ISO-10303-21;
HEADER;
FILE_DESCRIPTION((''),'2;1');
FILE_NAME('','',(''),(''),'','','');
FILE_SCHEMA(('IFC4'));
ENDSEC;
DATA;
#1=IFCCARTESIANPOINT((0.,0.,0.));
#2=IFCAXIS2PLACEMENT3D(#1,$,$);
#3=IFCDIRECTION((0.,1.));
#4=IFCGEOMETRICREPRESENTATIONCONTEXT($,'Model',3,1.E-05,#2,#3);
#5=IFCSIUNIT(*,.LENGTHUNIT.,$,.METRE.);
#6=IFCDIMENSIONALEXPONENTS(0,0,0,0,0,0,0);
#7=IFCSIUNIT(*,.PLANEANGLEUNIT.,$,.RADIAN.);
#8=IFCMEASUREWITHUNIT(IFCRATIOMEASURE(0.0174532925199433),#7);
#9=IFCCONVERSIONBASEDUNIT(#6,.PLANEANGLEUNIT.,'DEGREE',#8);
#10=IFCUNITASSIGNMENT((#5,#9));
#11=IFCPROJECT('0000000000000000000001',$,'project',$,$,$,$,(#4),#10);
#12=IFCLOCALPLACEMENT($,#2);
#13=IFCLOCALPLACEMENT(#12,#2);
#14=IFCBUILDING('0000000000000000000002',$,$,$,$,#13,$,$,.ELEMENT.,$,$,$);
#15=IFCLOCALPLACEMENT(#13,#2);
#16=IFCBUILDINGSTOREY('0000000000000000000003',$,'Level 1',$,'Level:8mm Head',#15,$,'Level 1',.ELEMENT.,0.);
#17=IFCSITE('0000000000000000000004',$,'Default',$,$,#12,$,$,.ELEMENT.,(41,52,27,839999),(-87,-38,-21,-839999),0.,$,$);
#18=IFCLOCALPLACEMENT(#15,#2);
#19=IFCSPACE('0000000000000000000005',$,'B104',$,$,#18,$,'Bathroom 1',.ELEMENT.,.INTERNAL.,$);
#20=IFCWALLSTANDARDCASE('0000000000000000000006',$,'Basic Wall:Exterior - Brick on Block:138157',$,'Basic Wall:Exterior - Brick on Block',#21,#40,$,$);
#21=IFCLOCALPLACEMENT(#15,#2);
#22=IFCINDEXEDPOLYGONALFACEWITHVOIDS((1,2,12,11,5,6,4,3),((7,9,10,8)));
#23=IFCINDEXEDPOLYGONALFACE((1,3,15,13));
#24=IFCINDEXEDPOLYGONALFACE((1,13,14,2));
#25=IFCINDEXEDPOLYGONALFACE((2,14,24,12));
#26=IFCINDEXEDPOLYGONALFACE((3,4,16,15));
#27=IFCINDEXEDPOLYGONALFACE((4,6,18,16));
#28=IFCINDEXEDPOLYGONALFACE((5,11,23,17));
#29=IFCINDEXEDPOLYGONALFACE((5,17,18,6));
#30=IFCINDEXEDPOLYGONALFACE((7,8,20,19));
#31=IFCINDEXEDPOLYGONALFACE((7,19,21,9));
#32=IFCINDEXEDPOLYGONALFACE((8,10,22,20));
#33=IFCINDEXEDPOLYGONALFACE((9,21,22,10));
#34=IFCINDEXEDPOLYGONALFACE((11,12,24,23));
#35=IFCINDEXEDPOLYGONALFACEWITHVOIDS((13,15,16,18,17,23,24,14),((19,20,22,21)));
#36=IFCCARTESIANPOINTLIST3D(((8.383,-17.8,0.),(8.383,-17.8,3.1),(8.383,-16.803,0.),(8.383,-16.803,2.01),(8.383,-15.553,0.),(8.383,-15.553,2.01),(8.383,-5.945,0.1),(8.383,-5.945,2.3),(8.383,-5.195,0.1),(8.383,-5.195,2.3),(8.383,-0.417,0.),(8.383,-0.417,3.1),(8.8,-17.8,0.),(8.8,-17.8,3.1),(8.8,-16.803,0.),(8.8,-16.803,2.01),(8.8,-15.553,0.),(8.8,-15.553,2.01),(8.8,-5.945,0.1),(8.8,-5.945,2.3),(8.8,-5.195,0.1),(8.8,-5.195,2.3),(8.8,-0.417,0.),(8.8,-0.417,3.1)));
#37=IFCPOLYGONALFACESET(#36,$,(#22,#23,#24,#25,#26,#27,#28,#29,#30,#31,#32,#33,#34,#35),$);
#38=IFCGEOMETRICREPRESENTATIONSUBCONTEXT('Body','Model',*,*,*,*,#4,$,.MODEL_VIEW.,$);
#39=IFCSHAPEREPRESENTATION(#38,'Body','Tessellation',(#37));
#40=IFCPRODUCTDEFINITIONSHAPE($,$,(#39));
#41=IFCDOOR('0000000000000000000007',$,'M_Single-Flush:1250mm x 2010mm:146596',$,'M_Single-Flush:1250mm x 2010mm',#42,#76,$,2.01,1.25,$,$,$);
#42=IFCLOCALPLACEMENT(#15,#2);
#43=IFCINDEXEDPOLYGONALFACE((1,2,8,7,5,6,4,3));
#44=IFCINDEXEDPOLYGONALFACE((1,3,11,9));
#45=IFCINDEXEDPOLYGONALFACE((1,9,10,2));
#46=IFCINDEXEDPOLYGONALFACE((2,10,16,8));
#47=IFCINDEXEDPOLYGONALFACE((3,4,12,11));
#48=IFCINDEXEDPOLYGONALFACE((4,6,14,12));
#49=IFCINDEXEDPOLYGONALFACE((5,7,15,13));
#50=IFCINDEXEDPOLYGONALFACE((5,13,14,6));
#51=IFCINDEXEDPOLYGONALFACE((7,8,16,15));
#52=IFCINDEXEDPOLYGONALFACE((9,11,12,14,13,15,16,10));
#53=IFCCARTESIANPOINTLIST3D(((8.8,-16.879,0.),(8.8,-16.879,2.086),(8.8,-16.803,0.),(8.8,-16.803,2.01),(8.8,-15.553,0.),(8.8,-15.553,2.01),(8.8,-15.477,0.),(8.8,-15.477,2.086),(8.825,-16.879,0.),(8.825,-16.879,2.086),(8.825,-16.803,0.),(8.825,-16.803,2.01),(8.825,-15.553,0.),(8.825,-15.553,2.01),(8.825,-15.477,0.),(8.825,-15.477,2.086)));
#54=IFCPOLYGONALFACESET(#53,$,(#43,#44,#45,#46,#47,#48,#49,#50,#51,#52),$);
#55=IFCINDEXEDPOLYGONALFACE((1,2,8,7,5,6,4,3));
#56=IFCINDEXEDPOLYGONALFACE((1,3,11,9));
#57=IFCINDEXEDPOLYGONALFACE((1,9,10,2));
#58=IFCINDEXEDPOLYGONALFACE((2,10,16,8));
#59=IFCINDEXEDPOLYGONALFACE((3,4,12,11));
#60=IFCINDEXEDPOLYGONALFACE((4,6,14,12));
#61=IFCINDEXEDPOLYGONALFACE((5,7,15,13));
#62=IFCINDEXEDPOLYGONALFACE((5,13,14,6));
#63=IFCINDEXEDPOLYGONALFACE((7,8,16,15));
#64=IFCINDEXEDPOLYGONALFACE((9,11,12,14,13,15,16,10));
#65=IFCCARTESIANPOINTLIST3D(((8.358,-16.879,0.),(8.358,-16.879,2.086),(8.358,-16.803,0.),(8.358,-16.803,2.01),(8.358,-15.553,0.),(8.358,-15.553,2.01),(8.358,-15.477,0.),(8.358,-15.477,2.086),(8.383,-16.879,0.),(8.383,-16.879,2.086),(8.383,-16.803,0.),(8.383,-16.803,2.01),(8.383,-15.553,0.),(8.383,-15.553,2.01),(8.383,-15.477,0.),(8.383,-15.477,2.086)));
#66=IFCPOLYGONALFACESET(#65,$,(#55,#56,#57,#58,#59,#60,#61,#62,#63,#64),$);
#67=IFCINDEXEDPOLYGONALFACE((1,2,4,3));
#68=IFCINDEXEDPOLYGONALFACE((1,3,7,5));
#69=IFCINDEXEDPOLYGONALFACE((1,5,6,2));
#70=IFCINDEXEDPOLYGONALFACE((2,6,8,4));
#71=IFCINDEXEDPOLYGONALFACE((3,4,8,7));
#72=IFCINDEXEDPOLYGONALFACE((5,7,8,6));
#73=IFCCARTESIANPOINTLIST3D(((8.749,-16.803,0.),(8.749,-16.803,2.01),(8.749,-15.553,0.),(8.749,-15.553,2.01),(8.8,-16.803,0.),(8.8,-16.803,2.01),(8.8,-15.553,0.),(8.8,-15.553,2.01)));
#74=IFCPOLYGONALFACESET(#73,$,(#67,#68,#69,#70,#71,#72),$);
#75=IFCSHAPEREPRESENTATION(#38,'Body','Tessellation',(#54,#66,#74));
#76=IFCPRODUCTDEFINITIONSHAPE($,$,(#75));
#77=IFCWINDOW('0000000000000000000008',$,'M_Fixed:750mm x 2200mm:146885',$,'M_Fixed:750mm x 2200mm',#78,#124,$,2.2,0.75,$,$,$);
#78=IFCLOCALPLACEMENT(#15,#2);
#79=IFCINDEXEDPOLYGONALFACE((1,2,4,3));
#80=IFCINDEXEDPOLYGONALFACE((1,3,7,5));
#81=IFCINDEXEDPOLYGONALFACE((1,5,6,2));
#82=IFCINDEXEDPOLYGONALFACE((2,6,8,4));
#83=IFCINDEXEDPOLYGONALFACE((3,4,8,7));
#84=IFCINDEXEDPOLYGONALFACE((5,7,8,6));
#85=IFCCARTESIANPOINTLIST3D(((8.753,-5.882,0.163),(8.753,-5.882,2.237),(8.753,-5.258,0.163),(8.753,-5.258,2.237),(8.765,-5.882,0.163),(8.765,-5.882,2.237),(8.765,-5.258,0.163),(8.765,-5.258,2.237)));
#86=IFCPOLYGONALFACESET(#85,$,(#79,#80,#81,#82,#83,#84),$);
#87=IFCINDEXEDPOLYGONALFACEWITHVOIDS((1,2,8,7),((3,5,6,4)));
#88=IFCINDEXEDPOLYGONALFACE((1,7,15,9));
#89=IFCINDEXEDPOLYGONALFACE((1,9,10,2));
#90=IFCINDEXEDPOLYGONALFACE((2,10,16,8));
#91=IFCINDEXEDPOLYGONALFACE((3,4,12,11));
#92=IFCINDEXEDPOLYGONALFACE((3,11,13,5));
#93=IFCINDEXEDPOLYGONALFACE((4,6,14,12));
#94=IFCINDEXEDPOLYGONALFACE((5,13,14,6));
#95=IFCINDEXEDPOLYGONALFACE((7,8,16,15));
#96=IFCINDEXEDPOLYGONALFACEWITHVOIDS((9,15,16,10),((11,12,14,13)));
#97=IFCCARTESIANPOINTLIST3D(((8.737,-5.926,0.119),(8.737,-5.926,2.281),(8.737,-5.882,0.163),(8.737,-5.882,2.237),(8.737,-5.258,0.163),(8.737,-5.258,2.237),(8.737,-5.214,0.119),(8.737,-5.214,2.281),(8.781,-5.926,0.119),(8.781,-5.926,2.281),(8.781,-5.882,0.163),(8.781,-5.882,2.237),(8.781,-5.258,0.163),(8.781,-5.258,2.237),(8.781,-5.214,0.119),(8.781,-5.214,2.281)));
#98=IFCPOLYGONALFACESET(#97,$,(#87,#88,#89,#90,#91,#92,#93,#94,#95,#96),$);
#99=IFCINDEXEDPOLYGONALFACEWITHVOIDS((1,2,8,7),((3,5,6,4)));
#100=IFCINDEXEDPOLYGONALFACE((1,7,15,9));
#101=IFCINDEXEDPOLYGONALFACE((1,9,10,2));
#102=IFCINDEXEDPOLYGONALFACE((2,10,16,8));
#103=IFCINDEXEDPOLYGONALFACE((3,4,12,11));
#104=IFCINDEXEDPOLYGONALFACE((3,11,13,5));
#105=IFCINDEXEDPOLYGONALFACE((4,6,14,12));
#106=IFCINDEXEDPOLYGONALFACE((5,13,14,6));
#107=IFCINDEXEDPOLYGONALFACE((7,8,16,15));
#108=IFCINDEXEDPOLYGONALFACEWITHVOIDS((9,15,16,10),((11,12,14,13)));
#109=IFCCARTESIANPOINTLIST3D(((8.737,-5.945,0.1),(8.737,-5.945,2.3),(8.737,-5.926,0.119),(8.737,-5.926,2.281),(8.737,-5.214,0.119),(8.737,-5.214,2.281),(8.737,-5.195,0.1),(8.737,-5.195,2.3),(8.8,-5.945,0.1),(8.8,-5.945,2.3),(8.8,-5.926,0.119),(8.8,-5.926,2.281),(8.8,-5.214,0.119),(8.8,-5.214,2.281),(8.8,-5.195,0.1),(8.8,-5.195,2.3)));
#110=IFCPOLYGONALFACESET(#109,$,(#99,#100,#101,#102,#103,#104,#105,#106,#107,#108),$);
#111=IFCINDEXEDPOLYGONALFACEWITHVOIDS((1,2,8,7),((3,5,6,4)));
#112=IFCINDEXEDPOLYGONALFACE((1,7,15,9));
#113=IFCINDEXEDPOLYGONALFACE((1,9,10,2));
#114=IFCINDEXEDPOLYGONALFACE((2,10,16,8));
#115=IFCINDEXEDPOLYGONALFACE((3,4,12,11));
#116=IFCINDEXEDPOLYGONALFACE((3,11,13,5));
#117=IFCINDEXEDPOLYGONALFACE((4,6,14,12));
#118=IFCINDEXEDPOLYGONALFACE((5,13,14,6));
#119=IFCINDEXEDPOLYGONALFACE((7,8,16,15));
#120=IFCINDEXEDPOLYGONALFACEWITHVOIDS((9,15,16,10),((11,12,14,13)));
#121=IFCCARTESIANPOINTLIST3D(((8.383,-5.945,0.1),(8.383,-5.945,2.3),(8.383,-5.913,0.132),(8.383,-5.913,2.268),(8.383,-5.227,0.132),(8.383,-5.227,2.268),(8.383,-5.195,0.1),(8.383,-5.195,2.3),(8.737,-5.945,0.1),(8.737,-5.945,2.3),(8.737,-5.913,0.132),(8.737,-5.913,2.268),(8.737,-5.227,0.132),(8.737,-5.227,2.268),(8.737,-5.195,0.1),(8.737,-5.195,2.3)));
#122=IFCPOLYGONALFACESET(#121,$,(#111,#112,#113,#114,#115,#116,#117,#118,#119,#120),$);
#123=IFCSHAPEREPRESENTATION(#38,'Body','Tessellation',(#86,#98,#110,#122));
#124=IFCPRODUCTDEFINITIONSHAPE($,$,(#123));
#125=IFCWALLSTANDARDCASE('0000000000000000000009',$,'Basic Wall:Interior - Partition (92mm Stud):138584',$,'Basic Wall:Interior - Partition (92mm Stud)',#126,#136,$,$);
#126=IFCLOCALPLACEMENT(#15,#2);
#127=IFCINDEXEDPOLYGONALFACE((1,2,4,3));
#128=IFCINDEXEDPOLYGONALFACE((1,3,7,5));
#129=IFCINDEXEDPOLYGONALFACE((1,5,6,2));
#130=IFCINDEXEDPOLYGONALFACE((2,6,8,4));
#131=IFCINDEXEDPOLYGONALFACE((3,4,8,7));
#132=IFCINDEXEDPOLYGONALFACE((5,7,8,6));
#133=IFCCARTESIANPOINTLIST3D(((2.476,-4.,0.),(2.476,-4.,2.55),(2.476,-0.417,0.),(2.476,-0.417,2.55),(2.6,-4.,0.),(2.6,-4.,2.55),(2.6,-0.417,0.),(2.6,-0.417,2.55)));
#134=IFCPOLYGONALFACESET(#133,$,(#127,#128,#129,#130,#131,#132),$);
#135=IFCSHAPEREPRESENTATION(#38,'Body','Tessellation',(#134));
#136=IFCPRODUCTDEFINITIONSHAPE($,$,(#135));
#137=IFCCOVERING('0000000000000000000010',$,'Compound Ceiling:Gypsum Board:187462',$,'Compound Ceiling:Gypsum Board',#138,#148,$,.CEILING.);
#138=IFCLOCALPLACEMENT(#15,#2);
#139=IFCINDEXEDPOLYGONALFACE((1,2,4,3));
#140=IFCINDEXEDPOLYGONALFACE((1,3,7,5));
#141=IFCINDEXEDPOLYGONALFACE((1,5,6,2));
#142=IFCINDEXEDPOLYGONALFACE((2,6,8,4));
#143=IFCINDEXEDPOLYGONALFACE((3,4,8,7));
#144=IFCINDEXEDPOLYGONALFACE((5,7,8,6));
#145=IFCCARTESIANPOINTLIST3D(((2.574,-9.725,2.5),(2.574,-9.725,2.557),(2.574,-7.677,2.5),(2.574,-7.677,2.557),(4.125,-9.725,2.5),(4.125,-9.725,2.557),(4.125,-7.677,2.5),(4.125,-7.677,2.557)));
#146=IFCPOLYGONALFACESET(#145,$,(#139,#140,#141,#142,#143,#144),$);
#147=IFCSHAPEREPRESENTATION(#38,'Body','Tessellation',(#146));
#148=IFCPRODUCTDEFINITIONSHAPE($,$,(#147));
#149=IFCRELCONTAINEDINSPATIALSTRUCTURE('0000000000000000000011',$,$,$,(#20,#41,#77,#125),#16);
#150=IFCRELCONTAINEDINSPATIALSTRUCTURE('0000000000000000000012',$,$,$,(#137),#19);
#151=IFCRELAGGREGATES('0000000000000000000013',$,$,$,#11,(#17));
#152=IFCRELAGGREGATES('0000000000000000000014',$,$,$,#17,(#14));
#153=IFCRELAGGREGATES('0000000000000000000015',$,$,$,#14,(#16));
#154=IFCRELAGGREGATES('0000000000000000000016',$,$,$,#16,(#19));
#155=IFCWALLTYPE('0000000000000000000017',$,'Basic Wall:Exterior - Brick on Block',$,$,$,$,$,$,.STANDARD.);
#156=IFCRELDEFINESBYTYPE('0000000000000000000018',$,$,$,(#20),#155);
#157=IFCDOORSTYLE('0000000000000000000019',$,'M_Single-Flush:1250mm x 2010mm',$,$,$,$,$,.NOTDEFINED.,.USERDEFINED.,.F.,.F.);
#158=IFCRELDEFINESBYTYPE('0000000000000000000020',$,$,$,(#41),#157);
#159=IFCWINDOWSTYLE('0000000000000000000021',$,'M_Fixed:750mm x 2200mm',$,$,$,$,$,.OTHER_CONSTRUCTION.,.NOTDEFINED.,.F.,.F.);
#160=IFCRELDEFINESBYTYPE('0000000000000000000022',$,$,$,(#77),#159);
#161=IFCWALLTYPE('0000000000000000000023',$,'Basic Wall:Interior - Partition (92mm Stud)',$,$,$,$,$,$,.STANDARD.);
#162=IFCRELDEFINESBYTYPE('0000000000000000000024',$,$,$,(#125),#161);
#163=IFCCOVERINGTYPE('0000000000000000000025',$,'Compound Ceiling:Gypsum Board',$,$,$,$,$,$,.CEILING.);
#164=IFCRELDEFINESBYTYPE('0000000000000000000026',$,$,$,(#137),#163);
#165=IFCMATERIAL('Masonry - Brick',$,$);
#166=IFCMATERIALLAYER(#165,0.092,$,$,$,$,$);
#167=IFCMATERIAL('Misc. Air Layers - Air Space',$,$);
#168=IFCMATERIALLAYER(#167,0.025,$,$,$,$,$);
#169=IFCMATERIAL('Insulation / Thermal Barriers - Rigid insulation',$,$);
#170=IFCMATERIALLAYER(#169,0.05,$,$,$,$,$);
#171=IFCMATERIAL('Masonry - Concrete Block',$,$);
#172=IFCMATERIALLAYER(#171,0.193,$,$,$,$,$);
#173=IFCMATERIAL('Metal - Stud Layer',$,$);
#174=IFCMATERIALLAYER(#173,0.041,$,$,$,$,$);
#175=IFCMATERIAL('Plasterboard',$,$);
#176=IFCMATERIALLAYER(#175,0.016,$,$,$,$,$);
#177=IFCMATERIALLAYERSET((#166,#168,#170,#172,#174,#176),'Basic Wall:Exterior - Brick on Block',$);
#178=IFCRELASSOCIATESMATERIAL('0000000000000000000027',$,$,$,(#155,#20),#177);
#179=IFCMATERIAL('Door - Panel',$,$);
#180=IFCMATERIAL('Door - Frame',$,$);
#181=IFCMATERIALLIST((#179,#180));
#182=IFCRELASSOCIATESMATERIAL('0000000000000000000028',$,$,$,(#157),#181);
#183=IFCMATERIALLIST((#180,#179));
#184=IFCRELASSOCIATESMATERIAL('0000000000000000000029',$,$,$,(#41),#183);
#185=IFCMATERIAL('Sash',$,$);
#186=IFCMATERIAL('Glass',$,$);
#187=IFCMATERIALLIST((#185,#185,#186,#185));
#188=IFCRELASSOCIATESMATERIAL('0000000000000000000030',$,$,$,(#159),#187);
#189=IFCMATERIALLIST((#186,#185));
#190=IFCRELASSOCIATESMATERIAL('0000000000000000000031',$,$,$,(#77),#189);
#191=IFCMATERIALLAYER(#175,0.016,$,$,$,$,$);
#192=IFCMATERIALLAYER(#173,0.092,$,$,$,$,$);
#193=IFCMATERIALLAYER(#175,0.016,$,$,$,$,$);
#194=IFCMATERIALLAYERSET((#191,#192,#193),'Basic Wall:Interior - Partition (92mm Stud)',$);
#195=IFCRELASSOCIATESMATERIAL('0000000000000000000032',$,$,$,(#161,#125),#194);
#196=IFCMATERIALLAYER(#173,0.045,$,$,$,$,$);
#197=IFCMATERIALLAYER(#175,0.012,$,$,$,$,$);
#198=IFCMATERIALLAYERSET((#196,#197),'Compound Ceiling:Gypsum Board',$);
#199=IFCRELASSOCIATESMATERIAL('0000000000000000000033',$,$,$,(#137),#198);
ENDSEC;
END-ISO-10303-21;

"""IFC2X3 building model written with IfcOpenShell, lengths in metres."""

from ifc_helpers import new_model, entity, si_unit, converted_unit, direction, frame, frame_2d, origin, origin_2d_with_axis, place, context, subcontext, project, spatial, polyline, rectangle, outline, extrude, source, transform, mapped, material, material_list, layer, layer_set, layer_usage, type_object, type_shapes, element, fill, save


model = new_model("IFC2X3")

# Units and contexts
model_context = context("Model", 3, precision=1e-05, world=origin(), true_north=direction((0.0, 1.0)))
body_context = subcontext(model_context, "Body", "Model", "MODEL_VIEW")
ifc_project = project(units=[si_unit("LENGTHUNIT", "METRE"), converted_unit("PLANEANGLEUNIT", "DEGREE", entity("IfcRatioMeasure", 0.0174532925199433), si_unit("PLANEANGLEUNIT", "RADIAN"), dimensions=[0, 0, 0, 0, 0, 0, 0])], contexts=[model_context])

# Site, building, storey
site_placement = place(None, origin())
site = spatial("IfcSite", under=ifc_project, at=site_placement, Name="Default", CompositionType="ELEMENT", RefLatitude=(41, 52, 27, 839999), RefLongitude=(-87, -38, -21, -839999), RefElevation=0.0)
building_placement = place(site_placement, origin())
building = spatial("IfcBuilding", under=site, at=building_placement, CompositionType="ELEMENT")
storey_placement = place(building_placement, origin())
storey = spatial("IfcBuildingStorey", under=building, at=storey_placement, Name="Level 1", ObjectType="Level:8mm Head", LongName="Level 1", CompositionType="ELEMENT", Elevation=0.0)

# Shared definitions
ifc_material_1 = material(Name="Masonry - Brick")
ifc_layer_1 = layer(ifc_material_1, 0.092)
ifc_material_2 = material(Name="Misc. Air Layers - Air Space")
ifc_layer_2 = layer(ifc_material_2, 0.025)
ifc_material_3 = material(Name="Insulation / Thermal Barriers - Rigid insulation")
ifc_layer_3 = layer(ifc_material_3, 0.05)
ifc_material_4 = material(Name="Masonry - Concrete Block")
ifc_layer_4 = layer(ifc_material_4, 0.193)
ifc_material_5 = material(Name="Metal - Stud Layer")
ifc_layer_5 = layer(ifc_material_5, 0.041)
ifc_material_6 = material(Name="Plasterboard")
ifc_layer_6 = layer(ifc_material_6, 0.016)
ifc_layer_set_1 = layer_set([ifc_layer_1, ifc_layer_2, ifc_layer_3, ifc_layer_4, ifc_layer_5, ifc_layer_6], Name="Basic Wall:Exterior - Brick on Block")
wall_type_1 = type_object("IfcWallType", Name="Basic Wall:Exterior - Brick on Block", PredefinedType="STANDARD", material=ifc_layer_set_1)
ifc_material_7 = material(Name="Glass")
ifc_material_8 = material(Name="Sash")
ifc_material_9 = material(Name="Door - Frame")
ifc_material_10 = material(Name="Door - Panel")

# Wall, openings, door, window
ifc_layer_usage_1 = layer_usage(ifc_layer_set_1, "AXIS2", "NEGATIVE", 0.2085)
wall_1_placement = place(storey_placement, frame((8.5915, -0.417, 0.0), z_axis=(0.0, 0.0, 1.0), x_axis=(0.0, -1.0, 0.0)))
wall_1 = element("IfcWallStandardCase", 1, at=wall_1_placement, inside=storey, type_object=wall_type_1, material=ifc_layer_usage_1, Name="Basic Wall:Exterior - Brick on Block:138157", ObjectType="Basic Wall:Exterior - Brick on Block", context=body_context, shape_type="SweptSolid", body=[
    extrude(rectangle(XDim=17.383, YDim=0.417, at=frame_2d((8.6915, 0.0), x_axis=(-1.0, 0.0))), origin(), (0.0, 0.0, 1.0), 3.1),
])
opening_1_placement = place(wall_1_placement, frame((15.136, -0.2085, 0.0)))
opening_1 = element("IfcOpeningElement", 2, at=opening_1_placement, cuts=wall_1, ObjectType="Opening", context=body_context, shape_type="SweptSolid", body=[
    extrude(rectangle(XDim=1.25, YDim=2.01, at=frame_2d((1.005, 0.625), x_axis=(0.0, 1.0))), frame((0.0, 0.0, 0.0), z_axis=(0.0, 1.0, 0.0), x_axis=(0.0, 0.0, 1.0)), (0.0, 0.0, 1.0), 0.417),
])
opening_2_placement = place(wall_1_placement, frame((4.778, -0.2085, 0.1)))
opening_2 = element("IfcOpeningElement", 3, at=opening_2_placement, cuts=wall_1, ObjectType="Opening", context=body_context, shape_type="SweptSolid", body=[
    extrude(rectangle(XDim=2.2, YDim=0.75, at=frame_2d((1.1, 0.375), x_axis=(1.0, 0.0))), frame((0.0, 0.0, 0.0), z_axis=(0.0, 1.0, 0.0), x_axis=(0.0, 0.0, 1.0)), (0.0, 0.0, 1.0), 0.417),
])
ifc_material_list_1 = material_list([ifc_material_9, ifc_material_10])
ifc_material_list_2 = material_list([ifc_material_10, ifc_material_9])
door_style_1 = type_object("IfcDoorStyle", Name="M_Single-Flush:1250mm x 2010mm", ConstructionType="USERDEFINED", OperationType="NOTDEFINED", ParameterTakesPrecedence=False, Sizeable=False, material=ifc_material_list_2)
shared_shape_1 = source(origin(), body_context, "Body", "SweptSolid", [
    extrude(outline(polyline([(-0.701, -1.062), (0.701, -1.062), (0.701, 1.024), (0.625, 1.024), (0.625, -0.986), (-0.625, -0.986), (-0.625, 1.024), (-0.701, 1.024), (-0.701, -1.062)])), frame((0.625, 0.417, 1.024), z_axis=(0.0, 1.0, 0.0), x_axis=(1.0, 0.0, 0.0)), (0.0, 0.0, 1.0), 0.025),
    extrude(outline(polyline([(-1.062, -0.701), (1.024, -0.701), (1.024, -0.625), (-0.986, -0.625), (-0.986, 0.625), (1.024, 0.625), (1.024, 0.701), (-1.062, 0.701), (-1.062, -0.701)])), frame((0.625, -0.025, 1.024), z_axis=(0.0, 1.0, 0.0), x_axis=(0.0, 0.0, -1.0)), (0.0, 0.0, 1.0), 0.025),
    extrude(rectangle(XDim=0.051, YDim=1.25, at=frame_2d((0.0, 0.0), x_axis=(1.0, 0.0))), frame((0.625, 0.3915, 0.0), z_axis=(0.0, 0.0, 1.0), x_axis=(0.0, 1.0, 0.0)), (0.0, 0.0, 1.0), 2.01),
])
type_shapes(door_style_1, [shared_shape_1])
door_1_placement = place(opening_1_placement, origin())
door_1 = element("IfcDoor", 4, at=door_1_placement, inside=storey, type_object=door_style_1, material=ifc_material_list_1, Name="M_Single-Flush:1250mm x 2010mm:146596", ObjectType="M_Single-Flush:1250mm x 2010mm", OverallHeight=2.01, OverallWidth=1.25, context=body_context, shape_type="MappedRepresentation", body=[
    mapped(shared_shape_1, transform((0.0, 0.0, 0.0), scale=1.0)),
])
fill(opening_1, door_1)
ifc_material_list_3 = material_list([ifc_material_7, ifc_material_8])
ifc_material_list_4 = material_list([ifc_material_8, ifc_material_8, ifc_material_7, ifc_material_8])
window_style_1 = type_object("IfcWindowStyle", Name="M_Fixed:750mm x 2200mm", ConstructionType="OTHER_CONSTRUCTION", OperationType="NOTDEFINED", ParameterTakesPrecedence=False, Sizeable=False, material=ifc_material_list_4)
shared_shape_2 = source(origin(), body_context, "Body", "SweptSolid", [
    extrude(rectangle(XDim=0.012, YDim=0.624, at=origin_2d_with_axis()), frame((0.375, 0.376, 0.063), z_axis=(0.0, 0.0, 1.0), x_axis=(0.0, -1.0, 0.0)), (0.0, 0.0, 1.0), 2.074),
    extrude(outline(polyline([(-0.356, -1.081), (0.356, -1.081), (0.356, 1.081), (-0.356, 1.081), (-0.356, -1.081)]), holes=[polyline([(-0.312, -1.037), (-0.312, 1.037), (0.312, 1.037), (0.312, -1.037), (-0.312, -1.037)])]), frame((0.375, 0.354, 1.1), z_axis=(0.0, 1.0, 0.0), x_axis=(1.0, 0.0, 0.0)), (0.0, 0.0, 1.0), 0.044),
    extrude(outline(polyline([(-0.375, -1.1), (0.375, -1.1), (0.375, 1.1), (-0.375, 1.1), (-0.375, -1.1)]), holes=[polyline([(-0.356, -1.081), (-0.356, 1.081), (0.356, 1.081), (0.356, -1.081), (-0.356, -1.081)])]), frame((0.375, 0.354, 1.1), z_axis=(0.0, 1.0, 0.0), x_axis=(1.0, 0.0, 0.0)), (0.0, 0.0, 1.0), 0.063),
    extrude(outline(polyline([(-0.375, -1.1), (0.375, -1.1), (0.375, 1.1), (-0.375, 1.1), (-0.375, -1.1)]), holes=[polyline([(-0.343, -1.068), (-0.343, 1.068), (0.343, 1.068), (0.343, -1.068), (-0.343, -1.068)])]), frame((0.375, 0.0, 1.1), z_axis=(0.0, 1.0, 0.0), x_axis=(1.0, 0.0, 0.0)), (0.0, 0.0, 1.0), 0.354),
])
type_shapes(window_style_1, [shared_shape_2])
window_1_placement = place(opening_2_placement, origin())
window_1 = element("IfcWindow", 5, at=window_1_placement, inside=storey, type_object=window_style_1, material=ifc_material_list_3, Name="M_Fixed:750mm x 2200mm:146885", ObjectType="M_Fixed:750mm x 2200mm", OverallHeight=2.2, OverallWidth=0.75, context=body_context, shape_type="MappedRepresentation", body=[
    mapped(shared_shape_2, transform((0.0, 0.0, 0.0), scale=1.0)),
])
fill(opening_2, window_1)

# Wall
ifc_layer_7 = layer(ifc_material_6, 0.016)
ifc_layer_8 = layer(ifc_material_5, 0.092)
ifc_layer_9 = layer(ifc_material_6, 0.016)
ifc_layer_set_2 = layer_set([ifc_layer_7, ifc_layer_8, ifc_layer_9], Name="Basic Wall:Interior - Partition (92mm Stud)")
ifc_layer_usage_2 = layer_usage(ifc_layer_set_2, "AXIS2", "NEGATIVE", 0.062)
wall_type_2 = type_object("IfcWallType", Name="Basic Wall:Interior - Partition (92mm Stud)", PredefinedType="STANDARD", material=ifc_layer_set_2)
wall_2_placement = place(storey_placement, frame((2.538, -0.417, 0.0), z_axis=(0.0, 0.0, 1.0), x_axis=(0.0, -1.0, 0.0)))
element("IfcWallStandardCase", 6, at=wall_2_placement, inside=storey, type_object=wall_type_2, material=ifc_layer_usage_2, Name="Basic Wall:Interior - Partition (92mm Stud):138584", ObjectType="Basic Wall:Interior - Partition (92mm Stud)", context=body_context, shape_type="SweptSolid", body=[
    extrude(rectangle(XDim=3.583, YDim=0.124, at=frame_2d((1.7915, 0.0), x_axis=(-1.0, 0.0))), origin(), (0.0, 0.0, 1.0), 2.55),
])

# Shared definitions
ifc_layer_10 = layer(ifc_material_5, 0.045)
ifc_layer_11 = layer(ifc_material_6, 0.012)
ifc_layer_set_3 = layer_set([ifc_layer_10, ifc_layer_11], Name="Compound Ceiling:Gypsum Board")

# Shared definitions
space_1_placement = place(storey_placement, origin())
space_1 = spatial("IfcSpace", under=storey, at=space_1_placement, Name="B104", LongName="Bathroom 1", CompositionType="ELEMENT", InteriorOrExteriorSpace="INTERNAL")

# Covering
ifc_layer_usage_3 = layer_usage(ifc_layer_set_3, "AXIS3", "POSITIVE", 0.0)
covering_type_1 = type_object("IfcCoveringType", Name="Compound Ceiling:Gypsum Board", PredefinedType="CEILING")
covering_1_placement = place(space_1_placement, origin())
element("IfcCovering", 7, at=covering_1_placement, inside=space_1, type_object=covering_type_1, material=ifc_layer_usage_3, Name="Compound Ceiling:Gypsum Board:187462", ObjectType="Compound Ceiling:Gypsum Board", PredefinedType="CEILING", context=body_context, shape_type="SweptSolid", body=[
    extrude(rectangle(XDim=1.551, YDim=2.048, at=frame_2d((0.0, 0.0), x_axis=(1.0, 0.0))), frame((3.3495, -8.701, 2.5)), (0.0, 0.0, 1.0), 0.057),
])

save(model, "model.ifc")
